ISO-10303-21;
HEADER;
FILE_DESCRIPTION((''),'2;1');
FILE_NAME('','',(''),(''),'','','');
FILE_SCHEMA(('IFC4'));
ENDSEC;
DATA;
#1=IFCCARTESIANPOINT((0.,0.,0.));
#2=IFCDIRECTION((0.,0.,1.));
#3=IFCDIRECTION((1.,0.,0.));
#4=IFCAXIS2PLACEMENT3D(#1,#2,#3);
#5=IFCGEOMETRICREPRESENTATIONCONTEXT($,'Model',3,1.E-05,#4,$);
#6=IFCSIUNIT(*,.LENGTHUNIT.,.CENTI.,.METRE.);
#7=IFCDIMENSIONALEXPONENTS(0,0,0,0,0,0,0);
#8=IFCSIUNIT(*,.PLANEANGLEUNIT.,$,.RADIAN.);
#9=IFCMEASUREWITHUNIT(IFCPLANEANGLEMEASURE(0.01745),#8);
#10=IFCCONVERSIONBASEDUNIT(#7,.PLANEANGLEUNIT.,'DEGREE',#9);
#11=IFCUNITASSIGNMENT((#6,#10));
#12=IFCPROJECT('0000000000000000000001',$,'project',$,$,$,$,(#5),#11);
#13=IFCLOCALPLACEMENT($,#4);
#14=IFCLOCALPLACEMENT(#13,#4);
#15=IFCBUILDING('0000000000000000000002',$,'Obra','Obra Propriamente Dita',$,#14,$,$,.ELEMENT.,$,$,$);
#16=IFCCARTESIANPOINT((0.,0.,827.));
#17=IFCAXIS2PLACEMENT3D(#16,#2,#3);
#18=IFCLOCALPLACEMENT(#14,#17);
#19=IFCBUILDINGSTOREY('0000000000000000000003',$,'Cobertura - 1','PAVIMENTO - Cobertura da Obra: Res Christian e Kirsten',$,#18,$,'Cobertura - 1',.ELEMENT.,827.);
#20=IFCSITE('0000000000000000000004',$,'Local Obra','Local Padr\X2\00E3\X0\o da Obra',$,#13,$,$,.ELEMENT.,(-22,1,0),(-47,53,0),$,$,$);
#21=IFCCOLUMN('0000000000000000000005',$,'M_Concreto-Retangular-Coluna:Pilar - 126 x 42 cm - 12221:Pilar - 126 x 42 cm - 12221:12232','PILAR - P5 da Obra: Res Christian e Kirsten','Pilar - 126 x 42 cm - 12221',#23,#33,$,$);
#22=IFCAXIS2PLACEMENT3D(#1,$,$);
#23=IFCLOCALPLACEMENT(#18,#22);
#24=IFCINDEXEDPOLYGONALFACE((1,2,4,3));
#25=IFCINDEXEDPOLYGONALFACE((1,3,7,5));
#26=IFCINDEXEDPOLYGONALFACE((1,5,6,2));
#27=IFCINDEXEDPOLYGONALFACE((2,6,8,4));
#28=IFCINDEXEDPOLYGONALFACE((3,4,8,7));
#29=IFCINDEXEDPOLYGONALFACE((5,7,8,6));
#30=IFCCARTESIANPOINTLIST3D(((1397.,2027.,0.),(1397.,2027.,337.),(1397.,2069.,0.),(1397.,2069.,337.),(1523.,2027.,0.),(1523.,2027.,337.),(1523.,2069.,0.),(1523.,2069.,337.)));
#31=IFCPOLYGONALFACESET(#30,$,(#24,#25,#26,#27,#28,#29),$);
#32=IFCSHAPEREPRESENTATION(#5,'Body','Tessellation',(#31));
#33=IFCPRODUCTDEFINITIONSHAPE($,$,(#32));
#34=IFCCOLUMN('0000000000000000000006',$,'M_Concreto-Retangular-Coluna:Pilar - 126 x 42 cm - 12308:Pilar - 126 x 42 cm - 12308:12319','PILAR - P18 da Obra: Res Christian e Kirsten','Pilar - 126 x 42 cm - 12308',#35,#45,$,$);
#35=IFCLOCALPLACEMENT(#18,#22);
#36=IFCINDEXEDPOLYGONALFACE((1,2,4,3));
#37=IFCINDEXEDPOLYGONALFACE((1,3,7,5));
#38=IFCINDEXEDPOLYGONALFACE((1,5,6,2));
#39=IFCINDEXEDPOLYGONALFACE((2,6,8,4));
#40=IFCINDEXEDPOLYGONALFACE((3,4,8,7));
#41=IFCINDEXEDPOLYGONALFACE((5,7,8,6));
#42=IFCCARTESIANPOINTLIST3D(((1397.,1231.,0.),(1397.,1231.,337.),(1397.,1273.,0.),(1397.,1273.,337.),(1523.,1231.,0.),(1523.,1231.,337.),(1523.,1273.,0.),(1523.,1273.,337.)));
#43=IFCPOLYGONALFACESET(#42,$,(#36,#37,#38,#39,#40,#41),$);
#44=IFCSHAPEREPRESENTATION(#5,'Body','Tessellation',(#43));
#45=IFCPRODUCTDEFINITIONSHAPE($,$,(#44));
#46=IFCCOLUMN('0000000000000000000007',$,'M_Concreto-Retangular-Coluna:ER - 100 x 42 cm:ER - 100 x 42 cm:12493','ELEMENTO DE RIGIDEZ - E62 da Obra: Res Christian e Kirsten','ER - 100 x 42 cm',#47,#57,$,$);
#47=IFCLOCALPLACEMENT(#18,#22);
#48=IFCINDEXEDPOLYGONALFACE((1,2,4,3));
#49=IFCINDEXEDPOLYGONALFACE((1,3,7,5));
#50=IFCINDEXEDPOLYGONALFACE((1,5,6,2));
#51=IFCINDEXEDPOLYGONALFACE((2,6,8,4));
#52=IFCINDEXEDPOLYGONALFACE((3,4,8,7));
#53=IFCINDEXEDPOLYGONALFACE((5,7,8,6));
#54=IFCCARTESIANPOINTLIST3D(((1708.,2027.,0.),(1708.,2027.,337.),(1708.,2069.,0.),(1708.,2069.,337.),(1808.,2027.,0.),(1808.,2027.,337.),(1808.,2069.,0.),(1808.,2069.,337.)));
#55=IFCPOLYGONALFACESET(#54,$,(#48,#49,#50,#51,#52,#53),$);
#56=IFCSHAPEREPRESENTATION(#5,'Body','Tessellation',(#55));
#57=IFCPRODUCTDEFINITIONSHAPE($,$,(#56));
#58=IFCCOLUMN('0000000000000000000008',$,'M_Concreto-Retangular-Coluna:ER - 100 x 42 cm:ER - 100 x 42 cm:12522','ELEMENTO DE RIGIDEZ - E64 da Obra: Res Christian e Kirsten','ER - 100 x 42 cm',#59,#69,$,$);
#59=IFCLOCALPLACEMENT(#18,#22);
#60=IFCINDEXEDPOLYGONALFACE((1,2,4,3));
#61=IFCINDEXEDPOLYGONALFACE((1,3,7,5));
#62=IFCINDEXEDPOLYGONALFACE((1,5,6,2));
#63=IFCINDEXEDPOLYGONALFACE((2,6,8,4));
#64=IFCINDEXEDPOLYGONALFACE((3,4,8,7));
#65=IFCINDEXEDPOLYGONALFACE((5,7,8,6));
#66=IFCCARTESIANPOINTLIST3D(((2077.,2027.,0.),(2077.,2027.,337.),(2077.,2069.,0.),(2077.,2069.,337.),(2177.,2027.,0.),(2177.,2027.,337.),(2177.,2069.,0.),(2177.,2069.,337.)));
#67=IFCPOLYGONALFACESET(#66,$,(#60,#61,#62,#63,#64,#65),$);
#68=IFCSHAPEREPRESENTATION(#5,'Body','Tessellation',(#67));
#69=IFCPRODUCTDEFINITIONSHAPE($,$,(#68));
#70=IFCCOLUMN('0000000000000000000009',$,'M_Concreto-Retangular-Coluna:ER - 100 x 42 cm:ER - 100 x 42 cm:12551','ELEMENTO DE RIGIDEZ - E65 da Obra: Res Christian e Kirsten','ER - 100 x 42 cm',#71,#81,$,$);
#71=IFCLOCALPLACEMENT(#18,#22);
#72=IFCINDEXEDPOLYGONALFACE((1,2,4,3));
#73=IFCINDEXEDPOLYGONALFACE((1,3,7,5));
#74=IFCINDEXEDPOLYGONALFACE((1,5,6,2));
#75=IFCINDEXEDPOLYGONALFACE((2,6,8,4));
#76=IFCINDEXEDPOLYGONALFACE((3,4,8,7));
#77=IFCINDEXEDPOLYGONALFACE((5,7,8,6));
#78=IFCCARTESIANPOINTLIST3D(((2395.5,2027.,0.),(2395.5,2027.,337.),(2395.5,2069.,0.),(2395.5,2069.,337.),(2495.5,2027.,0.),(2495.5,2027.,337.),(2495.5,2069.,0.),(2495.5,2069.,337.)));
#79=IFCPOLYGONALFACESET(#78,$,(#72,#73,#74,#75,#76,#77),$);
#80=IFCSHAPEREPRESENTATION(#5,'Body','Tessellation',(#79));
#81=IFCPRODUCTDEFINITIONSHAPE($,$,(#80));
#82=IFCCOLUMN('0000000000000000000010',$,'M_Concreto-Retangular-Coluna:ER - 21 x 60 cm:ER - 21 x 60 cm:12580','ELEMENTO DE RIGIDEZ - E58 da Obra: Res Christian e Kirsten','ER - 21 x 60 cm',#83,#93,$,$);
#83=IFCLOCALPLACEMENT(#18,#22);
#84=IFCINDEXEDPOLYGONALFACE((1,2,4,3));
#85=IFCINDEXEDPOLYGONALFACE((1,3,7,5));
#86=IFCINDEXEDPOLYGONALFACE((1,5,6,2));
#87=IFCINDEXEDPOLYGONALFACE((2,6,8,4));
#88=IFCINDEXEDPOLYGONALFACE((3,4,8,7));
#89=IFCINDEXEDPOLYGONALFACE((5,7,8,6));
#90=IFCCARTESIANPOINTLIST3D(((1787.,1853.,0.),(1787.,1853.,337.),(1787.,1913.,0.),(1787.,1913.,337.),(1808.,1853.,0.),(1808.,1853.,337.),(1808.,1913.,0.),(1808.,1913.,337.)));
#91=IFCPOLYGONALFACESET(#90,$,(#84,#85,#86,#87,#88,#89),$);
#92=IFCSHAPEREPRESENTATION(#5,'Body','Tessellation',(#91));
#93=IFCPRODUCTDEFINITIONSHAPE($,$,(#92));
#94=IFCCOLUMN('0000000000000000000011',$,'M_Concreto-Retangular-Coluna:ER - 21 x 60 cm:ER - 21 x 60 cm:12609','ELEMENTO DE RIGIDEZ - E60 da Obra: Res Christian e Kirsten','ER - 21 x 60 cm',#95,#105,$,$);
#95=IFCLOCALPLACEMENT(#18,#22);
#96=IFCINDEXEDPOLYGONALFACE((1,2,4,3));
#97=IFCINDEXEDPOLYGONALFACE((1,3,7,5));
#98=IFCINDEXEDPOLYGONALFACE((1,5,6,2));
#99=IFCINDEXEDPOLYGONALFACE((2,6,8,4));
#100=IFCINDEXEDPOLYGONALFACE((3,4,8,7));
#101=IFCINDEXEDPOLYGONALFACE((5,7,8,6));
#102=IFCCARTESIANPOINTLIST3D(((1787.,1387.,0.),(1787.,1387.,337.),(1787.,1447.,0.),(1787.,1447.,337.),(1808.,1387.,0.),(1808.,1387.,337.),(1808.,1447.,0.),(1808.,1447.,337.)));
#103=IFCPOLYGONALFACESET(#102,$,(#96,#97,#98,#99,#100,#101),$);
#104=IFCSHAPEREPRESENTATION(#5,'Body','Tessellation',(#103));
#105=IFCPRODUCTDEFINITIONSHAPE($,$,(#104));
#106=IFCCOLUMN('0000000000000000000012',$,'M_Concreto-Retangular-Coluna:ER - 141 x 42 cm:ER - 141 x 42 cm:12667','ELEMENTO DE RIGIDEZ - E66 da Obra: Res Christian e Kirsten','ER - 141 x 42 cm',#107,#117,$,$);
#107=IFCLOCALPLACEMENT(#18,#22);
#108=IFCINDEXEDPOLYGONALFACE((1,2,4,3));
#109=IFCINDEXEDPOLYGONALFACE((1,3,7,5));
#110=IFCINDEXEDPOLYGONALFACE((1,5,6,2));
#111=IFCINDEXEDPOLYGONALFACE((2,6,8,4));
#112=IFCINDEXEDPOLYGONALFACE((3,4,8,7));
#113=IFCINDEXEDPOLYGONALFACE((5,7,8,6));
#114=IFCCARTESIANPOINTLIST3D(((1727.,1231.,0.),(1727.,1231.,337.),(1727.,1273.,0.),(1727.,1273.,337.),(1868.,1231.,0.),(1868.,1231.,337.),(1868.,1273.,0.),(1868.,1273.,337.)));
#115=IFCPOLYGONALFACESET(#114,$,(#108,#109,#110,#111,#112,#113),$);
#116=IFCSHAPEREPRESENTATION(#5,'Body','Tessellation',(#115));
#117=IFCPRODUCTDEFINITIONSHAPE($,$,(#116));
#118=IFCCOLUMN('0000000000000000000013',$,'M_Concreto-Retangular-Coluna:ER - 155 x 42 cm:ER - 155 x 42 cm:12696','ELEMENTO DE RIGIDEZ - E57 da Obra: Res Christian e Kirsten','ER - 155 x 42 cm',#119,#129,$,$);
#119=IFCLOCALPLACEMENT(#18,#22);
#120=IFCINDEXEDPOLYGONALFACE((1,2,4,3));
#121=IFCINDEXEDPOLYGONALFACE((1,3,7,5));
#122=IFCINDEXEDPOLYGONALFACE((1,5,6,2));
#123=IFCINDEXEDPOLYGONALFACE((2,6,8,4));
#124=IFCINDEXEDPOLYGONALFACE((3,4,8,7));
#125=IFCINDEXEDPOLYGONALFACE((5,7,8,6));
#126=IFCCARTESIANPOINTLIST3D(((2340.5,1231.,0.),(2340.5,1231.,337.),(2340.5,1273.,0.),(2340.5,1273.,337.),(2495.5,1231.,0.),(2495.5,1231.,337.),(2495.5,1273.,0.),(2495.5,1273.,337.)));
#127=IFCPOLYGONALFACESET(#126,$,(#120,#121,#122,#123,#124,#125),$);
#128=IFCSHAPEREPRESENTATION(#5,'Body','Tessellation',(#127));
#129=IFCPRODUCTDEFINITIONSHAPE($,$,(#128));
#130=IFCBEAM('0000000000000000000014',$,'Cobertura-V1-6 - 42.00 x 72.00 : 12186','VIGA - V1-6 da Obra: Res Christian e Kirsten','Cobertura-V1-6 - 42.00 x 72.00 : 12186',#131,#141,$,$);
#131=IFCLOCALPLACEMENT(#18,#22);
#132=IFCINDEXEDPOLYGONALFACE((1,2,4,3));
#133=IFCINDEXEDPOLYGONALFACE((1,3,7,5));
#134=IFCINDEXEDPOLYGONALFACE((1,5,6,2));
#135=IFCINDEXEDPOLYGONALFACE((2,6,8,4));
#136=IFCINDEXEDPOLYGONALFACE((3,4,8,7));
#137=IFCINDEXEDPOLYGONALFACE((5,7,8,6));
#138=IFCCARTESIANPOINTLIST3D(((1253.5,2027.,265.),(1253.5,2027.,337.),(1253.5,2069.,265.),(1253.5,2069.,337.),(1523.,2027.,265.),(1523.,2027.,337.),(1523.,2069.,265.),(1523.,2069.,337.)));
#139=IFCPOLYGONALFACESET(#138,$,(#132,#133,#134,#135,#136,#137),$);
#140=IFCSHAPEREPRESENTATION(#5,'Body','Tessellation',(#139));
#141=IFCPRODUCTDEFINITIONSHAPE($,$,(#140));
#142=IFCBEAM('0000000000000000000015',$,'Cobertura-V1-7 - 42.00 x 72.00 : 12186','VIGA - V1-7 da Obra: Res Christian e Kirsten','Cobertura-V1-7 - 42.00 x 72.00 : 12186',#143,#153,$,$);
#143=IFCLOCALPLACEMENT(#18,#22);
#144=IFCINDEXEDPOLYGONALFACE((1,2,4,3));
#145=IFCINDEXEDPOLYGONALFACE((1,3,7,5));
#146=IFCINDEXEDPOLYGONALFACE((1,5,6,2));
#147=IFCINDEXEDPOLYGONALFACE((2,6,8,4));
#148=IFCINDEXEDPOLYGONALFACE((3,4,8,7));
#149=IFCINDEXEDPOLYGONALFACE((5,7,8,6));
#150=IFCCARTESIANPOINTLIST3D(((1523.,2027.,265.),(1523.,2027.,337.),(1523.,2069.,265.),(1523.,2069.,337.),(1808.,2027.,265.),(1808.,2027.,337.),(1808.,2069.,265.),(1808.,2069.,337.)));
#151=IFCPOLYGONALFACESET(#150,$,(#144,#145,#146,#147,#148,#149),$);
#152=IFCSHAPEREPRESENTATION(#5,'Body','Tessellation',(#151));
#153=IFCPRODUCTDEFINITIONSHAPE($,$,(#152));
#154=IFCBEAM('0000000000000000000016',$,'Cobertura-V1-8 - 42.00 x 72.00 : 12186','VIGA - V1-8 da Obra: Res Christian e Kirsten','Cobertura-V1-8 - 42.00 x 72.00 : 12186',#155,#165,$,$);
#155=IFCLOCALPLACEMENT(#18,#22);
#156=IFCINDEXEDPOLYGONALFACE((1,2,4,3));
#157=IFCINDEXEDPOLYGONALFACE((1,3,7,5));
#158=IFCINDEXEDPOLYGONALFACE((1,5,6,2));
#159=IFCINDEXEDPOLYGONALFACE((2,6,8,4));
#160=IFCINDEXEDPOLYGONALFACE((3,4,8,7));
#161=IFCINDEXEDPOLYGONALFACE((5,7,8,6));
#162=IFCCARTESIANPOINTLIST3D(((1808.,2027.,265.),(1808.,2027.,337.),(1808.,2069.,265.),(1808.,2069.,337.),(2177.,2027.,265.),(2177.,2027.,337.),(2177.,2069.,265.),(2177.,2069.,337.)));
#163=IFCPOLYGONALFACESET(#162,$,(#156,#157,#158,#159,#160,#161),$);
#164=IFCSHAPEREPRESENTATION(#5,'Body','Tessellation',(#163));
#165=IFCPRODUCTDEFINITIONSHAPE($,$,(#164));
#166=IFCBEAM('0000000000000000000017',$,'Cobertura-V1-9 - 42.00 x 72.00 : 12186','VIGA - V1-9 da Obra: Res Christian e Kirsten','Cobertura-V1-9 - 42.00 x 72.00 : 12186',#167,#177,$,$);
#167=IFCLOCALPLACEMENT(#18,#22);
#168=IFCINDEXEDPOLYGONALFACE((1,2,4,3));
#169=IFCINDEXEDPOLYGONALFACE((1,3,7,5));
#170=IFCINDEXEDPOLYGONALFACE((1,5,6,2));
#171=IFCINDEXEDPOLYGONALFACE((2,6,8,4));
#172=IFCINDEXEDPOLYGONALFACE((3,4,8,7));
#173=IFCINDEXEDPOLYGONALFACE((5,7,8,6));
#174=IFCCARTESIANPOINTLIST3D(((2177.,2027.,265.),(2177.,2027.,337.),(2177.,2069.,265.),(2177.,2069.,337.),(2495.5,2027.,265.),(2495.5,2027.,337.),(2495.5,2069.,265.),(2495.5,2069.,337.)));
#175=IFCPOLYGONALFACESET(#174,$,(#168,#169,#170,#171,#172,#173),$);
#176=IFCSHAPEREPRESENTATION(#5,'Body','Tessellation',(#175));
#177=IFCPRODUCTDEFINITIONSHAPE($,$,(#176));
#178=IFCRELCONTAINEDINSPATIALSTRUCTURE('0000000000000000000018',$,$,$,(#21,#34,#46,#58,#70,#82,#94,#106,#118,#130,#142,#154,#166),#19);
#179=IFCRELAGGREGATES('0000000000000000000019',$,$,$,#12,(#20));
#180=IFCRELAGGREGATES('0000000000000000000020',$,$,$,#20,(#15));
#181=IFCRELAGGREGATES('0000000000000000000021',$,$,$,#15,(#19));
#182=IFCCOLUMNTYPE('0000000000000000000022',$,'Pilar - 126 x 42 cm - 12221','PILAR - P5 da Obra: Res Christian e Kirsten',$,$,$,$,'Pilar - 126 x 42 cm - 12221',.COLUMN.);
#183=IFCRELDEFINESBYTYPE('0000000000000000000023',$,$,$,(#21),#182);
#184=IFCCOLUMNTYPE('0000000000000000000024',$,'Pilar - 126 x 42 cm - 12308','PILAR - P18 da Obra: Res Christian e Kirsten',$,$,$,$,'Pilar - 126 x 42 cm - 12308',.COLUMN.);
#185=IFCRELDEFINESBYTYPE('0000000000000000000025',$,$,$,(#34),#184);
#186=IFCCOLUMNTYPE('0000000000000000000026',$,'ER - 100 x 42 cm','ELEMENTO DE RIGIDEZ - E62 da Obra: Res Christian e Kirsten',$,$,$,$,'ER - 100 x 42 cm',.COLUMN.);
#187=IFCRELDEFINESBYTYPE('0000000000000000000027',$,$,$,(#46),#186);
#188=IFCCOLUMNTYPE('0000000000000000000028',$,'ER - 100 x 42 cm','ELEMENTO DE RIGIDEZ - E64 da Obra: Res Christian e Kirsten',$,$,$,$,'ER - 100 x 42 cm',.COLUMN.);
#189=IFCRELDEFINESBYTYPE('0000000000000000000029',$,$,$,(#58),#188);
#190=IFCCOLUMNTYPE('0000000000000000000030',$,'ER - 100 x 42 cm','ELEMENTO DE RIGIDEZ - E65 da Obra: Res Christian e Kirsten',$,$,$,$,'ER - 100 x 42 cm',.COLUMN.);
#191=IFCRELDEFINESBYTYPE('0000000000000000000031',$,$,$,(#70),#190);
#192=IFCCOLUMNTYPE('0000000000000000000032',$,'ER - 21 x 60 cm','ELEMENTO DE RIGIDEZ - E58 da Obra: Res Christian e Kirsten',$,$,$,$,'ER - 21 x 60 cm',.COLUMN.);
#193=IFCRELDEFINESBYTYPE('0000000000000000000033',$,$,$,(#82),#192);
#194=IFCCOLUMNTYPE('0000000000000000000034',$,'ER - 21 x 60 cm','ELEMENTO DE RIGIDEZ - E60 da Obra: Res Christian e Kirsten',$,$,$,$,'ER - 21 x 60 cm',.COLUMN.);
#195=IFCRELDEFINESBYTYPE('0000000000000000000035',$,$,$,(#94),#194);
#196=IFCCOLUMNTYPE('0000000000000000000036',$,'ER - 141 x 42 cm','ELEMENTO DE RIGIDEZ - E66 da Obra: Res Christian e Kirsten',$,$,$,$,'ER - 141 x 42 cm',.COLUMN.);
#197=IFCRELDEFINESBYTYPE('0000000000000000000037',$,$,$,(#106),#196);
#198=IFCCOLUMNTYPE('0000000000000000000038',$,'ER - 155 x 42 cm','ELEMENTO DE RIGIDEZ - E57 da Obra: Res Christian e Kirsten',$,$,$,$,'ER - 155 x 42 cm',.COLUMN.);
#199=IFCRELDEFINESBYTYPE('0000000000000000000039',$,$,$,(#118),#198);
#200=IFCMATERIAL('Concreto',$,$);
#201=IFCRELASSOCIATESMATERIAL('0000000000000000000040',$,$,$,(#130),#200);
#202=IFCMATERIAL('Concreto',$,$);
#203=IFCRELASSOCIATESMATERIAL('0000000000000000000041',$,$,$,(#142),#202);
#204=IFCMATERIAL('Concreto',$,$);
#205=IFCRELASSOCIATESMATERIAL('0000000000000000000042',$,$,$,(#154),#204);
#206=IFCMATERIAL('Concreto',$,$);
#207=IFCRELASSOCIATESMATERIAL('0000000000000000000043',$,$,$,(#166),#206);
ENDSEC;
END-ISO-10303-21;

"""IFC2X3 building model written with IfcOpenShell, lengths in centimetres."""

from ifc_helpers import new_model, entity, si_unit, converted_unit, frame, origin, origin_with_axes, origin_2d_with_axis, place, context, project, spatial, polyline, rectangle, outline, extrude, source, transform, mapped, material, type_object, type_shapes, element, save


model = new_model("IFC2X3")

# Units and contexts
model_context = context("Model", 3, precision=1e-05, world=origin_with_axes())
ifc_project = project(units=[si_unit("LENGTHUNIT", "METRE", prefix="CENTI"), converted_unit("PLANEANGLEUNIT", "DEGREE", entity("IfcPlaneAngleMeasure", 0.01745), si_unit("PLANEANGLEUNIT", "RADIAN"), dimensions=[0, 0, 0, 0, 0, 0, 0])], contexts=[model_context])

# Site, building, storey
site_placement = place(None, origin_with_axes())
site = spatial("IfcSite", under=ifc_project, at=site_placement, Name="Local Obra", Description="Local Padrão da Obra", CompositionType="ELEMENT", RefLatitude=(-22, 1, 0), RefLongitude=(-47, 53, 0))
building_placement = place(site_placement, origin_with_axes())
building = spatial("IfcBuilding", under=site, at=building_placement, Name="Obra", Description="Obra Propriamente Dita", CompositionType="ELEMENT")
storey_placement = place(building_placement, frame((0.0, 0.0, 827.0), z_axis=(0.0, 0.0, 1.0), x_axis=(1.0, 0.0, 0.0)))
storey = spatial("IfcBuildingStorey", under=building, at=storey_placement, Name="Cobertura - 1", Description="PAVIMENTO - Cobertura da Obra: Res Christian e Kirsten", LongName="Cobertura - 1", CompositionType="ELEMENT", Elevation=827.0)

# Columns
column_type_1 = type_object("IfcColumnType", Name="Pilar - 126 x 42 cm - 12221", Description="PILAR - P5 da Obra: Res Christian e Kirsten", ElementType="Pilar - 126 x 42 cm - 12221", PredefinedType="COLUMN")
shared_shape_1 = source(origin(), model_context, "Body", "SweptSolid", [
    extrude(rectangle(XDim=126.0, YDim=42.0, at=origin_2d_with_axis()), origin(), (0.0, 0.0, 1.0), 337.0),
])
type_shapes(column_type_1, [shared_shape_1])
column_1_placement = place(storey_placement, frame((1460.0, 2048.0, 0.0), z_axis=(0.0, 0.0, 1.0), x_axis=(1.0, 0.0, 0.0)))
element("IfcColumn", 1, at=column_1_placement, inside=storey, type_object=column_type_1, Name="M_Concreto-Retangular-Coluna:Pilar - 126 x 42 cm - 12221:Pilar - 126 x 42 cm - 12221:12232", Description="PILAR - P5 da Obra: Res Christian e Kirsten", ObjectType="Pilar - 126 x 42 cm - 12221", context=model_context, shape_type="MappedRepresentation", body=[
    mapped(shared_shape_1, transform((0.0, 0.0, 0.0), scale=1.0)),
])
column_type_2 = type_object("IfcColumnType", Name="Pilar - 126 x 42 cm - 12308", Description="PILAR - P18 da Obra: Res Christian e Kirsten", ElementType="Pilar - 126 x 42 cm - 12308", PredefinedType="COLUMN")
shared_shape_2 = source(origin(), model_context, "Body", "SweptSolid", [
    extrude(rectangle(XDim=126.0, YDim=42.0, at=origin_2d_with_axis()), origin(), (0.0, 0.0, 1.0), 337.0),
])
type_shapes(column_type_2, [shared_shape_2])
column_2_placement = place(storey_placement, frame((1460.0, 1252.0, 0.0), z_axis=(0.0, 0.0, 1.0), x_axis=(1.0, 0.0, 0.0)))
element("IfcColumn", 2, at=column_2_placement, inside=storey, type_object=column_type_2, Name="M_Concreto-Retangular-Coluna:Pilar - 126 x 42 cm - 12308:Pilar - 126 x 42 cm - 12308:12319", Description="PILAR - P18 da Obra: Res Christian e Kirsten", ObjectType="Pilar - 126 x 42 cm - 12308", context=model_context, shape_type="MappedRepresentation", body=[
    mapped(shared_shape_2, transform((0.0, 0.0, 0.0), scale=1.0)),
])
column_type_3 = type_object("IfcColumnType", Name="ER - 100 x 42 cm", Description="ELEMENTO DE RIGIDEZ - E62 da Obra: Res Christian e Kirsten", ElementType="ER - 100 x 42 cm", PredefinedType="COLUMN")
shared_shape_3 = source(origin(), model_context, "Body", "SweptSolid", [
    extrude(rectangle(XDim=100.0, YDim=42.0, at=origin_2d_with_axis()), origin(), (0.0, 0.0, 1.0), 337.0),
])
type_shapes(column_type_3, [shared_shape_3])
column_3_placement = place(storey_placement, frame((1758.0, 2048.0, 0.0), z_axis=(0.0, 0.0, 1.0), x_axis=(1.0, 0.0, 0.0)))
element("IfcColumn", 3, at=column_3_placement, inside=storey, type_object=column_type_3, Name="M_Concreto-Retangular-Coluna:ER - 100 x 42 cm:ER - 100 x 42 cm:12493", Description="ELEMENTO DE RIGIDEZ - E62 da Obra: Res Christian e Kirsten", ObjectType="ER - 100 x 42 cm", context=model_context, shape_type="MappedRepresentation", body=[
    mapped(shared_shape_3, transform((0.0, 0.0, 0.0), scale=1.0)),
])
column_type_4 = type_object("IfcColumnType", Name="ER - 100 x 42 cm", Description="ELEMENTO DE RIGIDEZ - E64 da Obra: Res Christian e Kirsten", ElementType="ER - 100 x 42 cm", PredefinedType="COLUMN")
shared_shape_4 = source(origin(), model_context, "Body", "SweptSolid", [
    extrude(rectangle(XDim=100.0, YDim=42.0, at=origin_2d_with_axis()), origin(), (0.0, 0.0, 1.0), 337.0),
])
type_shapes(column_type_4, [shared_shape_4])
column_4_placement = place(storey_placement, frame((2127.0, 2048.0, 0.0), z_axis=(0.0, 0.0, 1.0), x_axis=(1.0, 0.0, 0.0)))
element("IfcColumn", 4, at=column_4_placement, inside=storey, type_object=column_type_4, Name="M_Concreto-Retangular-Coluna:ER - 100 x 42 cm:ER - 100 x 42 cm:12522", Description="ELEMENTO DE RIGIDEZ - E64 da Obra: Res Christian e Kirsten", ObjectType="ER - 100 x 42 cm", context=model_context, shape_type="MappedRepresentation", body=[
    mapped(shared_shape_4, transform((0.0, 0.0, 0.0), scale=1.0)),
])
column_type_5 = type_object("IfcColumnType", Name="ER - 100 x 42 cm", Description="ELEMENTO DE RIGIDEZ - E65 da Obra: Res Christian e Kirsten", ElementType="ER - 100 x 42 cm", PredefinedType="COLUMN")
shared_shape_5 = source(origin(), model_context, "Body", "SweptSolid", [
    extrude(rectangle(XDim=100.0, YDim=42.0, at=origin_2d_with_axis()), origin(), (0.0, 0.0, 1.0), 337.0),
])
type_shapes(column_type_5, [shared_shape_5])
column_5_placement = place(storey_placement, frame((2445.5, 2048.0, 0.0), z_axis=(0.0, 0.0, 1.0), x_axis=(1.0, 0.0, 0.0)))
element("IfcColumn", 5, at=column_5_placement, inside=storey, type_object=column_type_5, Name="M_Concreto-Retangular-Coluna:ER - 100 x 42 cm:ER - 100 x 42 cm:12551", Description="ELEMENTO DE RIGIDEZ - E65 da Obra: Res Christian e Kirsten", ObjectType="ER - 100 x 42 cm", context=model_context, shape_type="MappedRepresentation", body=[
    mapped(shared_shape_5, transform((0.0, 0.0, 0.0), scale=1.0)),
])
column_type_6 = type_object("IfcColumnType", Name="ER - 21 x 60 cm", Description="ELEMENTO DE RIGIDEZ - E58 da Obra: Res Christian e Kirsten", ElementType="ER - 21 x 60 cm", PredefinedType="COLUMN")
shared_shape_6 = source(origin(), model_context, "Body", "SweptSolid", [
    extrude(rectangle(XDim=21.0, YDim=60.0, at=origin_2d_with_axis()), origin(), (0.0, 0.0, 1.0), 337.0),
])
type_shapes(column_type_6, [shared_shape_6])
column_6_placement = place(storey_placement, frame((1797.5, 1883.0, 0.0), z_axis=(0.0, 0.0, 1.0), x_axis=(1.0, 0.0, 0.0)))
element("IfcColumn", 6, at=column_6_placement, inside=storey, type_object=column_type_6, Name="M_Concreto-Retangular-Coluna:ER - 21 x 60 cm:ER - 21 x 60 cm:12580", Description="ELEMENTO DE RIGIDEZ - E58 da Obra: Res Christian e Kirsten", ObjectType="ER - 21 x 60 cm", context=model_context, shape_type="MappedRepresentation", body=[
    mapped(shared_shape_6, transform((0.0, 0.0, 0.0), scale=1.0)),
])
column_type_7 = type_object("IfcColumnType", Name="ER - 21 x 60 cm", Description="ELEMENTO DE RIGIDEZ - E60 da Obra: Res Christian e Kirsten", ElementType="ER - 21 x 60 cm", PredefinedType="COLUMN")
shared_shape_7 = source(origin(), model_context, "Body", "SweptSolid", [
    extrude(rectangle(XDim=21.0, YDim=60.0, at=origin_2d_with_axis()), origin(), (0.0, 0.0, 1.0), 337.0),
])
type_shapes(column_type_7, [shared_shape_7])
column_7_placement = place(storey_placement, frame((1797.5, 1417.0, 0.0), z_axis=(0.0, 0.0, 1.0), x_axis=(1.0, 0.0, 0.0)))
element("IfcColumn", 7, at=column_7_placement, inside=storey, type_object=column_type_7, Name="M_Concreto-Retangular-Coluna:ER - 21 x 60 cm:ER - 21 x 60 cm:12609", Description="ELEMENTO DE RIGIDEZ - E60 da Obra: Res Christian e Kirsten", ObjectType="ER - 21 x 60 cm", context=model_context, shape_type="MappedRepresentation", body=[
    mapped(shared_shape_7, transform((0.0, 0.0, 0.0), scale=1.0)),
])
column_type_8 = type_object("IfcColumnType", Name="ER - 141 x 42 cm", Description="ELEMENTO DE RIGIDEZ - E66 da Obra: Res Christian e Kirsten", ElementType="ER - 141 x 42 cm", PredefinedType="COLUMN")
shared_shape_8 = source(origin(), model_context, "Body", "SweptSolid", [
    extrude(rectangle(XDim=141.0, YDim=42.0, at=origin_2d_with_axis()), origin(), (0.0, 0.0, 1.0), 337.0),
])
type_shapes(column_type_8, [shared_shape_8])
column_8_placement = place(storey_placement, frame((1797.5, 1252.0, 0.0), z_axis=(0.0, 0.0, 1.0), x_axis=(1.0, 0.0, 0.0)))
element("IfcColumn", 8, at=column_8_placement, inside=storey, type_object=column_type_8, Name="M_Concreto-Retangular-Coluna:ER - 141 x 42 cm:ER - 141 x 42 cm:12667", Description="ELEMENTO DE RIGIDEZ - E66 da Obra: Res Christian e Kirsten", ObjectType="ER - 141 x 42 cm", context=model_context, shape_type="MappedRepresentation", body=[
    mapped(shared_shape_8, transform((0.0, 0.0, 0.0), scale=1.0)),
])
column_type_9 = type_object("IfcColumnType", Name="ER - 155 x 42 cm", Description="ELEMENTO DE RIGIDEZ - E57 da Obra: Res Christian e Kirsten", ElementType="ER - 155 x 42 cm", PredefinedType="COLUMN")
shared_shape_9 = source(origin(), model_context, "Body", "SweptSolid", [
    extrude(rectangle(XDim=155.0, YDim=42.0, at=origin_2d_with_axis()), origin(), (0.0, 0.0, 1.0), 337.0),
])
type_shapes(column_type_9, [shared_shape_9])
column_9_placement = place(storey_placement, frame((2418.0, 1252.0, 0.0), z_axis=(0.0, 0.0, 1.0), x_axis=(1.0, 0.0, 0.0)))
element("IfcColumn", 9, at=column_9_placement, inside=storey, type_object=column_type_9, Name="M_Concreto-Retangular-Coluna:ER - 155 x 42 cm:ER - 155 x 42 cm:12696", Description="ELEMENTO DE RIGIDEZ - E57 da Obra: Res Christian e Kirsten", ObjectType="ER - 155 x 42 cm", context=model_context, shape_type="MappedRepresentation", body=[
    mapped(shared_shape_9, transform((0.0, 0.0, 0.0), scale=1.0)),
])

# Beams
ifc_material_1 = material(Name="Concreto")
beam_1_placement = place(storey_placement, frame((1253.5, 2048.0, 337.0), z_axis=(1.0, 0.0, 0.0), x_axis=(0.0, -1.0, 0.0)))
element("IfcBeam", 10, at=beam_1_placement, inside=storey, material=ifc_material_1, Name="Cobertura-V1-6 - 42.00 x 72.00 : 12186", Description="VIGA - V1-6 da Obra: Res Christian e Kirsten", ObjectType="Cobertura-V1-6 - 42.00 x 72.00 : 12186", context=model_context, shape_type="SweptSolid", body=[
    extrude(outline(polyline([(-21.0, 0.0), (21.0, 0.0), (21.0, 72.0), (-21.0, 72.0), (-21.0, 0.0)])), origin_with_axes(), (0.0, 0.0, 1.0), 269.5),
])
ifc_material_2 = material(Name="Concreto")
beam_2_placement = place(storey_placement, frame((1523.0, 2048.0, 337.0), z_axis=(1.0, 0.0, 0.0), x_axis=(0.0, -1.0, 0.0)))
element("IfcBeam", 11, at=beam_2_placement, inside=storey, material=ifc_material_2, Name="Cobertura-V1-7 - 42.00 x 72.00 : 12186", Description="VIGA - V1-7 da Obra: Res Christian e Kirsten", ObjectType="Cobertura-V1-7 - 42.00 x 72.00 : 12186", context=model_context, shape_type="SweptSolid", body=[
    extrude(outline(polyline([(-21.0, 0.0), (21.0, 0.0), (21.0, 72.0), (-21.0, 72.0), (-21.0, 0.0)])), origin_with_axes(), (0.0, 0.0, 1.0), 285.0),
])
ifc_material_3 = material(Name="Concreto")
beam_3_placement = place(storey_placement, frame((1808.0, 2048.0, 337.0), z_axis=(1.0, 0.0, 0.0), x_axis=(0.0, -1.0, 0.0)))
element("IfcBeam", 12, at=beam_3_placement, inside=storey, material=ifc_material_3, Name="Cobertura-V1-8 - 42.00 x 72.00 : 12186", Description="VIGA - V1-8 da Obra: Res Christian e Kirsten", ObjectType="Cobertura-V1-8 - 42.00 x 72.00 : 12186", context=model_context, shape_type="SweptSolid", body=[
    extrude(outline(polyline([(-21.0, 0.0), (21.0, 0.0), (21.0, 72.0), (-21.0, 72.0), (-21.0, 0.0)])), origin_with_axes(), (0.0, 0.0, 1.0), 369.0),
])
ifc_material_4 = material(Name="Concreto")
beam_4_placement = place(storey_placement, frame((2177.0, 2048.0, 337.0), z_axis=(1.0, 0.0, 0.0), x_axis=(0.0, -1.0, 0.0)))
element("IfcBeam", 13, at=beam_4_placement, inside=storey, material=ifc_material_4, Name="Cobertura-V1-9 - 42.00 x 72.00 : 12186", Description="VIGA - V1-9 da Obra: Res Christian e Kirsten", ObjectType="Cobertura-V1-9 - 42.00 x 72.00 : 12186", context=model_context, shape_type="SweptSolid", body=[
    extrude(outline(polyline([(-21.0, 0.0), (21.0, 0.0), (21.0, 72.0), (-21.0, 72.0), (-21.0, 0.0)])), origin_with_axes(), (0.0, 0.0, 1.0), 318.5),
])

save(model, "model.ifc")
